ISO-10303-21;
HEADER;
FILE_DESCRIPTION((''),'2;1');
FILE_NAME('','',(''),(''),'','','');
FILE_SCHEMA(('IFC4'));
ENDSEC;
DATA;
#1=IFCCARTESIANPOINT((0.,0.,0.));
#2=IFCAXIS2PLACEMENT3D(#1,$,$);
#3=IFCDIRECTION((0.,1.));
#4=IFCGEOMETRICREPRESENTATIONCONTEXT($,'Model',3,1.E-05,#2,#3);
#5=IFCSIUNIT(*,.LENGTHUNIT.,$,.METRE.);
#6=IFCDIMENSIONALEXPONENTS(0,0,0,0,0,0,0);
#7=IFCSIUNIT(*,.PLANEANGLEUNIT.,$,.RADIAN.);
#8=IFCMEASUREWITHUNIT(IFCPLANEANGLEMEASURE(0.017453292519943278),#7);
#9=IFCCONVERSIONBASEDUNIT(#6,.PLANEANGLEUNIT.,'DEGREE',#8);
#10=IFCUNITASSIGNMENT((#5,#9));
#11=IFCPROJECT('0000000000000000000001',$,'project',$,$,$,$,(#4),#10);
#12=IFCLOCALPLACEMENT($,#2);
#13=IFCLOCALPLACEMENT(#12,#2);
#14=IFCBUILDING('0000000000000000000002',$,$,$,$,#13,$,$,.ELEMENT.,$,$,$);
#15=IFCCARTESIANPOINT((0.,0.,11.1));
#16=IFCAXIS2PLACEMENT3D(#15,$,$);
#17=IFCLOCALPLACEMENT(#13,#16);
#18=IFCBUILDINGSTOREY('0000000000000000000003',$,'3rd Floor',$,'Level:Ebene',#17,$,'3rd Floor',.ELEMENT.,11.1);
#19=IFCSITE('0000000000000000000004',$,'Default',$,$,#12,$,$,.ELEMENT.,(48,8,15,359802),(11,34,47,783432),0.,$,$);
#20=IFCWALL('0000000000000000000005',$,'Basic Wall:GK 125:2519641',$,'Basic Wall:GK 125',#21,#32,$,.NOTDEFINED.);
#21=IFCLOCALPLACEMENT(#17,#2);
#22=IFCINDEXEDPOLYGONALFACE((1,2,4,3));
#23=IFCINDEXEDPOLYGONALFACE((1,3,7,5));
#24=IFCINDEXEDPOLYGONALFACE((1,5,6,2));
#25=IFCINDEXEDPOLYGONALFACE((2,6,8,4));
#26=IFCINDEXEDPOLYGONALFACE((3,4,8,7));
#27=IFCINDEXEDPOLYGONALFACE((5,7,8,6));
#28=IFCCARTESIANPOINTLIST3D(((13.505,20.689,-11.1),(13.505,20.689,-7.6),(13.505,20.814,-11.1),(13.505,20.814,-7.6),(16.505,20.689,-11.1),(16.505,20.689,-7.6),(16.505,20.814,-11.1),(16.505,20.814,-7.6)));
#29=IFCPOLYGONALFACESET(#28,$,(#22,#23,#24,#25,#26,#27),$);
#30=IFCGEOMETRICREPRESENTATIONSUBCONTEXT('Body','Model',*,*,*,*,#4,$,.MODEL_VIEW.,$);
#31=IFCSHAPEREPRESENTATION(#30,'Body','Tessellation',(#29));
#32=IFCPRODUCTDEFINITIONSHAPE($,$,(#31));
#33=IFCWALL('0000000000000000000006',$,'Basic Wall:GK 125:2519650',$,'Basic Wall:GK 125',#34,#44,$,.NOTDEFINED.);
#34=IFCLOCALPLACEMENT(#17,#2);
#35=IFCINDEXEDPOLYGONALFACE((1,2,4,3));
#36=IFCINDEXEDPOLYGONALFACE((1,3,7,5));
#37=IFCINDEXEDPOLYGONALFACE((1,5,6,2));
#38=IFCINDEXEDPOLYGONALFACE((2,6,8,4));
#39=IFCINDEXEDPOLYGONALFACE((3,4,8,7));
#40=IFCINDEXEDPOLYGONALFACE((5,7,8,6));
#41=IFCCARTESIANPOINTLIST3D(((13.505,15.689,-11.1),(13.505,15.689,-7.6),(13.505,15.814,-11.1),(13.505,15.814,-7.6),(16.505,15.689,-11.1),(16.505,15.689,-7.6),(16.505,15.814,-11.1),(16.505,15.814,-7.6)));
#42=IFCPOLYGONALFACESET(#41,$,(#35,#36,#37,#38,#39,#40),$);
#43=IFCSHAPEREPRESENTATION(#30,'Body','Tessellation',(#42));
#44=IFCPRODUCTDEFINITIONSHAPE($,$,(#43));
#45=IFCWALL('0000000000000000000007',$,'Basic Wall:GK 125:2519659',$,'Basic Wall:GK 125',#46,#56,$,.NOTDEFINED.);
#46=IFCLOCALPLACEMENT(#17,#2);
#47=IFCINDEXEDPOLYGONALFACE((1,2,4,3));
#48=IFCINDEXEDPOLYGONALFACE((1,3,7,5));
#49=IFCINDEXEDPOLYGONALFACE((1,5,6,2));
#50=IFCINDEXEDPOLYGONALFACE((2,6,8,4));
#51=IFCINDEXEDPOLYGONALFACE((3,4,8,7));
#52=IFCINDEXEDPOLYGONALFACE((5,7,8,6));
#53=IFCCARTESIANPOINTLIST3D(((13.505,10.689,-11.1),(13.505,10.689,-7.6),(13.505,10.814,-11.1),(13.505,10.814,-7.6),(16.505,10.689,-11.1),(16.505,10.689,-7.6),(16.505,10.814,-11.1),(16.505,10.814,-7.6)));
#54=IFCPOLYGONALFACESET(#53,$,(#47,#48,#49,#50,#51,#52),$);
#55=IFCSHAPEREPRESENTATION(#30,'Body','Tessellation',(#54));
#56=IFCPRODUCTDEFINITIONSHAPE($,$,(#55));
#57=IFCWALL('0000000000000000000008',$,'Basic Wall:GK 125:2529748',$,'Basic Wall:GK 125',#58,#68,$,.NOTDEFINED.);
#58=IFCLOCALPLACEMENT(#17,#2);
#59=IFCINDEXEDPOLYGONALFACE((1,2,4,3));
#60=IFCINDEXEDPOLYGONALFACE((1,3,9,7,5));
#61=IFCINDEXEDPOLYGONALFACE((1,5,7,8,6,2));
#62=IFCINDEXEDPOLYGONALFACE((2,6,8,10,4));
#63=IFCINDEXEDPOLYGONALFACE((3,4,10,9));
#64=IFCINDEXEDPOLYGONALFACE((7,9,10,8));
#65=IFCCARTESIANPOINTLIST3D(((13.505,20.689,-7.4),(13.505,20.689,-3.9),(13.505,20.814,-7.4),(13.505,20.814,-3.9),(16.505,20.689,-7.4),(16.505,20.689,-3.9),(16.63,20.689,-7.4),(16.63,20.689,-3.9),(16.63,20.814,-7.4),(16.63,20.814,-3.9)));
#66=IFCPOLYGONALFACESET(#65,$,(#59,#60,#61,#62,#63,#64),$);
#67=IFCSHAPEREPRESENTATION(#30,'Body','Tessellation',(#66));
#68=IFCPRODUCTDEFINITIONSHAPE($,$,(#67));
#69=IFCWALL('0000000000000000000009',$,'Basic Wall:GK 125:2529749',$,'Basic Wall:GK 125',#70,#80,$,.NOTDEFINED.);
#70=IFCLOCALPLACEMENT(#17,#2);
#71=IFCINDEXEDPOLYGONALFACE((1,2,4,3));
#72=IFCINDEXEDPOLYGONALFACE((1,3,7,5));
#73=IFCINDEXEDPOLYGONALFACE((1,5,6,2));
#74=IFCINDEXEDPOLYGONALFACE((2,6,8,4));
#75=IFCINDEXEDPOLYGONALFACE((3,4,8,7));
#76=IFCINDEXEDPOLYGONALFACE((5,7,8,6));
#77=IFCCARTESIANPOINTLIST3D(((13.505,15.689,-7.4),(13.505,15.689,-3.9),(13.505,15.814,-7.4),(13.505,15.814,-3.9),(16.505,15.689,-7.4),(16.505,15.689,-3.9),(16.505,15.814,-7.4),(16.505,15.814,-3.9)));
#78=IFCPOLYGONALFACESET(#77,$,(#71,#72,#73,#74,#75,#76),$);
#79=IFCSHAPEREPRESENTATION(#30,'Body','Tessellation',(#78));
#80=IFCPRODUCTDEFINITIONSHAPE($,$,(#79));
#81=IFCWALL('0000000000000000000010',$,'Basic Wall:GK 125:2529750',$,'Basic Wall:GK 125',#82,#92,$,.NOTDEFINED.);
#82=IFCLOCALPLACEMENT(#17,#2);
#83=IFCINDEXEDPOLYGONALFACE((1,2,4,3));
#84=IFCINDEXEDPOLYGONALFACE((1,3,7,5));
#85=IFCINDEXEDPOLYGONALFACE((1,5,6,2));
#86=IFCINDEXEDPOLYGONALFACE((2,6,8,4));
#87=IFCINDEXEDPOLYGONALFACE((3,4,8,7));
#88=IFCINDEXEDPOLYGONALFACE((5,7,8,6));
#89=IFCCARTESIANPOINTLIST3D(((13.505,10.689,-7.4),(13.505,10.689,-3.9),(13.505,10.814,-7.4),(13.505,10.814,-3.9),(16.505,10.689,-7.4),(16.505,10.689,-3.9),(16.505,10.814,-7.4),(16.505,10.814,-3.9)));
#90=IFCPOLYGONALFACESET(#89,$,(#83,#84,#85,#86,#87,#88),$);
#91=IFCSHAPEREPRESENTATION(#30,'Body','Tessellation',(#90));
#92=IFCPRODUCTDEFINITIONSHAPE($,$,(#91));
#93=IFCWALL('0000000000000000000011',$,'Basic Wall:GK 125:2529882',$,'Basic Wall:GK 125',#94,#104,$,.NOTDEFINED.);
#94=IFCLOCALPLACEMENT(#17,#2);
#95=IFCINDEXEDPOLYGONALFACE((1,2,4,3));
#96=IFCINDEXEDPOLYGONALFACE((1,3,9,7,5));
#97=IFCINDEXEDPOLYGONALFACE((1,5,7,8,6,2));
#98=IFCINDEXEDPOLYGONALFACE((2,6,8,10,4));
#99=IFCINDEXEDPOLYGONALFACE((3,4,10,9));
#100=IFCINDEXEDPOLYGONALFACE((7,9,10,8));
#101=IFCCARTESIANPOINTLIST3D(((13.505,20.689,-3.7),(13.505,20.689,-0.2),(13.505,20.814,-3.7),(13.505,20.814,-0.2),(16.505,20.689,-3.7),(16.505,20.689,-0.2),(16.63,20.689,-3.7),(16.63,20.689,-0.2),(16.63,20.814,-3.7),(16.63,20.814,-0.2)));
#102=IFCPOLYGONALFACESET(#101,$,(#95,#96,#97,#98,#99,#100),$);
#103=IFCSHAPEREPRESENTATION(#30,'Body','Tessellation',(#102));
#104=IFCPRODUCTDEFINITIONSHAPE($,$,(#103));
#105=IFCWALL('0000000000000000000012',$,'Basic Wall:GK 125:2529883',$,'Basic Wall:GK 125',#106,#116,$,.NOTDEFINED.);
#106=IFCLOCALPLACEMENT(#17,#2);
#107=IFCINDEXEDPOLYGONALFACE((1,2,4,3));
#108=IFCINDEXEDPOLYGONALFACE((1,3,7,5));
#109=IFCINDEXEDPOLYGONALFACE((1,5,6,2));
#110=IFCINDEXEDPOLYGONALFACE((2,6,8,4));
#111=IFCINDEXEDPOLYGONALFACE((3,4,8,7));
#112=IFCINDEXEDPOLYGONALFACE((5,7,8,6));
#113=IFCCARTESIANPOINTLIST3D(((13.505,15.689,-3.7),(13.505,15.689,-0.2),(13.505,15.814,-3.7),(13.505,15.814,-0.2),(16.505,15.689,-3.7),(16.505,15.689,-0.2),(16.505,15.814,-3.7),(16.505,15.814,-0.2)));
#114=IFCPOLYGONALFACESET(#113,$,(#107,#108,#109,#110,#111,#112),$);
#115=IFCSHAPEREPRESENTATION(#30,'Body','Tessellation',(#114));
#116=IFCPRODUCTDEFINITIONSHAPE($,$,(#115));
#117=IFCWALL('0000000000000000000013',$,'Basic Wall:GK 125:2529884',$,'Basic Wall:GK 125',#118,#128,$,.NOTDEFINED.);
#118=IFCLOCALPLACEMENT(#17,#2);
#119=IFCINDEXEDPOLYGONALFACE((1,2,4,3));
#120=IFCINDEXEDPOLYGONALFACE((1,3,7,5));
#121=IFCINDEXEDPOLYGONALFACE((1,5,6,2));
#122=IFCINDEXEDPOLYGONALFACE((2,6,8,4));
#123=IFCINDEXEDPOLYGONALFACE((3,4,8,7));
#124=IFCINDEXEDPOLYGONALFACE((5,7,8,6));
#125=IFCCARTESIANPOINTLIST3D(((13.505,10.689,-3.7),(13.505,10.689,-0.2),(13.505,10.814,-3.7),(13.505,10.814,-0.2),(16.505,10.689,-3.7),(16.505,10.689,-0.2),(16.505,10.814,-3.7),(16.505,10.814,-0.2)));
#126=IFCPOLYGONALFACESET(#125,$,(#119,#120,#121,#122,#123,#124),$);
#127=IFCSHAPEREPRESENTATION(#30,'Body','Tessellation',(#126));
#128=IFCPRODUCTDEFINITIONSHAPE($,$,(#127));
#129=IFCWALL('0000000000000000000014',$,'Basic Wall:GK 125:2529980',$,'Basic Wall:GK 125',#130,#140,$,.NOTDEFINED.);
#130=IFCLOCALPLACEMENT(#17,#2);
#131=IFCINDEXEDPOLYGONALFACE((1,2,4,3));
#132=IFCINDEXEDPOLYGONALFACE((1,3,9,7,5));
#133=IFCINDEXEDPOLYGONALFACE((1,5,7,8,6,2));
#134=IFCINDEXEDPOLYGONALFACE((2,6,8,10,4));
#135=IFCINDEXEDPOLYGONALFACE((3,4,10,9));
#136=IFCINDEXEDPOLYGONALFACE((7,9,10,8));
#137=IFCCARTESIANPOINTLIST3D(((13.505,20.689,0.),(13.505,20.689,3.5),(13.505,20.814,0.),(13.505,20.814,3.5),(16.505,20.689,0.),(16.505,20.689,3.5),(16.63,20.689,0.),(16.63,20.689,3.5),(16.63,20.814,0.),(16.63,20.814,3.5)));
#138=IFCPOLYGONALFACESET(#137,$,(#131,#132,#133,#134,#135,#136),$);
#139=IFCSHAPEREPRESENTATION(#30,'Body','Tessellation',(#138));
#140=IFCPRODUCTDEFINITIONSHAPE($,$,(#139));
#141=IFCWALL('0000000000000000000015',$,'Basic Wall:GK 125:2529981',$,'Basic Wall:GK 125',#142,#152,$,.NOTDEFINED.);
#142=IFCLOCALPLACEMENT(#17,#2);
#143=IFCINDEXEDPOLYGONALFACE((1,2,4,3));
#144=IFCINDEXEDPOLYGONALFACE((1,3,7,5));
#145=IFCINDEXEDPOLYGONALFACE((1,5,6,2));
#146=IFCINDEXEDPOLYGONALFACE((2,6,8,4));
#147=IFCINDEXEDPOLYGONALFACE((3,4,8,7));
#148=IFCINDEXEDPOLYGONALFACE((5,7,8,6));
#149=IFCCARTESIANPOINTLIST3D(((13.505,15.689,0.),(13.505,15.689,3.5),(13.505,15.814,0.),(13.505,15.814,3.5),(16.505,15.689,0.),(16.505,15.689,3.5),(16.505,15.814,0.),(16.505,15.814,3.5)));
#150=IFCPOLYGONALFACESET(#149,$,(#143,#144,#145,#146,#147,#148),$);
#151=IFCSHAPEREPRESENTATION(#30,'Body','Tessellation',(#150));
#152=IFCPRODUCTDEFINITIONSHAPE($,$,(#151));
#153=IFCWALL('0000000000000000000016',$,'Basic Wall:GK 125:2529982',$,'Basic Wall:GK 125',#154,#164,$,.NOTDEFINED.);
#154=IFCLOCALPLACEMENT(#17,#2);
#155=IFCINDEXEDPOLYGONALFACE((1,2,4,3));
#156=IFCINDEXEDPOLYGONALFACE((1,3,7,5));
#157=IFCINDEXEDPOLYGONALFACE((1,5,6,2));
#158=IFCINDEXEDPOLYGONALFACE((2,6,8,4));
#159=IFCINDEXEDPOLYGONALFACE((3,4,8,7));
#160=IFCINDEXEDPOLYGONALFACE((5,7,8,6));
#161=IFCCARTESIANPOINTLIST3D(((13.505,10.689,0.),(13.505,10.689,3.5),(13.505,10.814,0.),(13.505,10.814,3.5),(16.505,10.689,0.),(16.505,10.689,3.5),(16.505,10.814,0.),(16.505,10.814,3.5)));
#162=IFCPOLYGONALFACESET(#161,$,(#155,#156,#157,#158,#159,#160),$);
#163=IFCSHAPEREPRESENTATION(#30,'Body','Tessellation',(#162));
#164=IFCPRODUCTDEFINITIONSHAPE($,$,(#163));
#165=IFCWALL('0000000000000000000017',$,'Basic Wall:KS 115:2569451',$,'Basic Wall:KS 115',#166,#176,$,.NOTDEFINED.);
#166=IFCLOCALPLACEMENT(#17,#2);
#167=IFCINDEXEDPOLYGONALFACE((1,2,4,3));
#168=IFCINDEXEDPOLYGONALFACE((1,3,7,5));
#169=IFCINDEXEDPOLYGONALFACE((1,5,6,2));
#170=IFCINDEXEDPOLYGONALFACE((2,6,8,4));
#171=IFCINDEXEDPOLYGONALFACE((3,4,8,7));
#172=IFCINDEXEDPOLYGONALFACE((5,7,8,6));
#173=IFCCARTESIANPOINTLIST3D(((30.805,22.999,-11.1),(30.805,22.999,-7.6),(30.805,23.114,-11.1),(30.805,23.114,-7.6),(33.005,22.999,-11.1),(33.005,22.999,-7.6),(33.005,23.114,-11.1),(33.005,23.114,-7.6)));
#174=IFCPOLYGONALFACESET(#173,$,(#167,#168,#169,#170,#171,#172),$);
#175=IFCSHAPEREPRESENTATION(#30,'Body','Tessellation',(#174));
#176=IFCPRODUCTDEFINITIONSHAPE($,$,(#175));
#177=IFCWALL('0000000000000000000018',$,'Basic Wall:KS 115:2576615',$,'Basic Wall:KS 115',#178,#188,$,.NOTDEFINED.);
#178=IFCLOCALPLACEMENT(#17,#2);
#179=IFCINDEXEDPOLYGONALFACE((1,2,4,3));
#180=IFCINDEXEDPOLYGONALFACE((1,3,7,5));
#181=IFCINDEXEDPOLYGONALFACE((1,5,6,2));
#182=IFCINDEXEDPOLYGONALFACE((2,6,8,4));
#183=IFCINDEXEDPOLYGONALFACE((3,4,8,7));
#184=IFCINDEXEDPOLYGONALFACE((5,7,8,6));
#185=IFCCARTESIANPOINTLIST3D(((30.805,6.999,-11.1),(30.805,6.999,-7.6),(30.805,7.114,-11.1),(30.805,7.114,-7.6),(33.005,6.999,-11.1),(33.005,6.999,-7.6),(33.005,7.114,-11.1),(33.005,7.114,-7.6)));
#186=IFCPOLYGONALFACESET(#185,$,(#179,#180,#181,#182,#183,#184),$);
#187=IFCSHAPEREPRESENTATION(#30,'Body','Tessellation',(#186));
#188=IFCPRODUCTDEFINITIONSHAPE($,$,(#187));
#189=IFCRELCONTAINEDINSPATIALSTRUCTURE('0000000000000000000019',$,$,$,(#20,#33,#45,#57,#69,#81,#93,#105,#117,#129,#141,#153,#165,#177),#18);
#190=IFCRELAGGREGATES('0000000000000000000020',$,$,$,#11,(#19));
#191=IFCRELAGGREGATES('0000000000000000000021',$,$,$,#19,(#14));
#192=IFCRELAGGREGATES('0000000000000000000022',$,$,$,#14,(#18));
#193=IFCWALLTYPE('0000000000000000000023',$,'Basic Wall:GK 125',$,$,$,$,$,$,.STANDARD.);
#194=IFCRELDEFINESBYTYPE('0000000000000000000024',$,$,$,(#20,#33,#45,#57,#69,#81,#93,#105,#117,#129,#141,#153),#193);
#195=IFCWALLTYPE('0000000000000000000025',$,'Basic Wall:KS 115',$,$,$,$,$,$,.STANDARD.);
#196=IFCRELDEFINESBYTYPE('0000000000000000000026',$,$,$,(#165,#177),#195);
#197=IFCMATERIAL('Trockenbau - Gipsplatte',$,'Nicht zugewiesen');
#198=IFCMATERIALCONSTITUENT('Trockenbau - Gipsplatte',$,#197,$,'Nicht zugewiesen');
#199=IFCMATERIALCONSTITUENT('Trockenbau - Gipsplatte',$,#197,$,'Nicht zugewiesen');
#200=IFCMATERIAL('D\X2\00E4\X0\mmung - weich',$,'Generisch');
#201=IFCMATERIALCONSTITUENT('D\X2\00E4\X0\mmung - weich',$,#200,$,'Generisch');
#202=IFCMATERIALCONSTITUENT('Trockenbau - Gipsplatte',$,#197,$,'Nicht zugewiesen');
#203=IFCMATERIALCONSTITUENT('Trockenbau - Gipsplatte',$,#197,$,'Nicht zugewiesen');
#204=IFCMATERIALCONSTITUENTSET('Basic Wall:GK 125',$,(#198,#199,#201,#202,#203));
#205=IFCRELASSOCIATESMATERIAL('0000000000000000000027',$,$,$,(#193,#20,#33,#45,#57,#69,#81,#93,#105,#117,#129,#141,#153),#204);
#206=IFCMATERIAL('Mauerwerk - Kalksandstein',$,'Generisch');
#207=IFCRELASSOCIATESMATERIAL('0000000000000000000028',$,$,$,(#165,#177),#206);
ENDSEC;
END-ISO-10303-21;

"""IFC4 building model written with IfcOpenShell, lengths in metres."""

from ifc_helpers import new_model, entity, si_unit, converted_unit, direction, frame, origin, place, context, subcontext, project, spatial, indexed_curve, outline, extrude, material, constituent, constituent_set, type_object, element, save


model = new_model("IFC4")

# Units and contexts
model_context = context("Model", 3, precision=1e-05, world=origin(), true_north=direction((0.0, 1.0)))
body_context = subcontext(model_context, "Body", "Model", "MODEL_VIEW")
ifc_project = project(units=[si_unit("LENGTHUNIT", "METRE"), converted_unit("PLANEANGLEUNIT", "DEGREE", entity("IfcPlaneAngleMeasure", 0.017453292519943278), si_unit("PLANEANGLEUNIT", "RADIAN"), dimensions=[0, 0, 0, 0, 0, 0, 0])], contexts=[model_context])

# Site, building, storey
site_placement = place(None, origin())
site = spatial("IfcSite", under=ifc_project, at=site_placement, Name="Default", CompositionType="ELEMENT", RefLatitude=(48, 8, 15, 359802), RefLongitude=(11, 34, 47, 783432), RefElevation=0.0)
building_placement = place(site_placement, origin())
building = spatial("IfcBuilding", under=site, at=building_placement, CompositionType="ELEMENT")
storey_placement = place(building_placement, frame((0.0, 0.0, 11.1)))
storey = spatial("IfcBuildingStorey", under=building, at=storey_placement, Name="3rd Floor", ObjectType="Level:Ebene", LongName="3rd Floor", CompositionType="ELEMENT", Elevation=11.1)

# Walls
ifc_material_1 = material(Name="Trockenbau - Gipsplatte", Category="Nicht zugewiesen")
ifc_constituent_1 = constituent(ifc_material_1, Name="Trockenbau - Gipsplatte", Category="Nicht zugewiesen")
ifc_constituent_2 = constituent(ifc_material_1, Name="Trockenbau - Gipsplatte", Category="Nicht zugewiesen")
ifc_material_2 = material(Name="Dämmung - weich", Category="Generisch")
ifc_constituent_3 = constituent(ifc_material_2, Name="Dämmung - weich", Category="Generisch")
ifc_constituent_4 = constituent(ifc_material_1, Name="Trockenbau - Gipsplatte", Category="Nicht zugewiesen")
ifc_constituent_5 = constituent(ifc_material_1, Name="Trockenbau - Gipsplatte", Category="Nicht zugewiesen")
ifc_constituent_set = constituent_set(constituents=[ifc_constituent_1, ifc_constituent_2, ifc_constituent_3, ifc_constituent_4, ifc_constituent_5], Name="Basic Wall:GK 125")
wall_type_1 = type_object("IfcWallType", Name="Basic Wall:GK 125", PredefinedType="STANDARD", material=ifc_constituent_set)
wall_1_placement = place(storey_placement, frame((13.505, 20.7515, -11.1)))
element("IfcWall", 1, at=wall_1_placement, inside=storey, type_object=wall_type_1, material=ifc_constituent_set, Name="Basic Wall:GK 125:2519641", ObjectType="Basic Wall:GK 125", PredefinedType="NOTDEFINED", context=body_context, shape_type="SweptSolid", body=[
    extrude(outline(indexed_curve([(3.0, -0.0625), (3.0, 0.0625), (0.0, 0.0625), (0.0, -0.0625), (3.0, -0.0625)], self_intersect=False)), origin(), (0.0, 0.0, 1.0), 3.5),
])
for number, where, name in (
    (2, (13.505, 15.7515, -11.1), "Basic Wall:GK 125:2519650"),
    (3, (13.505, 10.7515, -11.1), "Basic Wall:GK 125:2519659"),
):
    element("IfcWall", number, at=place(storey_placement, frame(where)), inside=storey, type_object=wall_type_1, material=ifc_constituent_set, Name=name, ObjectType="Basic Wall:GK 125", PredefinedType="NOTDEFINED", context=body_context, shape_type="SweptSolid", body=[
        extrude(outline(indexed_curve([(3.0, -0.0625), (3.0, 0.0625), (0.0, 0.0625), (0.0, -0.0625), (3.0, -0.0625)], self_intersect=False)), origin(), (0.0, 0.0, 1.0), 3.5),
    ])
wall_2_placement = place(storey_placement, frame((13.505, 20.7515, -7.4)))
element("IfcWall", 4, at=wall_2_placement, inside=storey, type_object=wall_type_1, material=ifc_constituent_set, Name="Basic Wall:GK 125:2529748", ObjectType="Basic Wall:GK 125", PredefinedType="NOTDEFINED", context=body_context, shape_type="SweptSolid", body=[
    extrude(outline(indexed_curve([(3.125, -0.0625), (3.125, 0.0625), (0.0, 0.0625), (0.0, -0.0625), (3.0, -0.0625), (3.125, -0.0625)], self_intersect=False)), origin(), (0.0, 0.0, 1.0), 3.5),
])
for number, where, name in (
    (5, (13.505, 15.7515, -7.4), "Basic Wall:GK 125:2529749"),
    (6, (13.505, 10.7515, -7.4), "Basic Wall:GK 125:2529750"),
):
    element("IfcWall", number, at=place(storey_placement, frame(where)), inside=storey, type_object=wall_type_1, material=ifc_constituent_set, Name=name, ObjectType="Basic Wall:GK 125", PredefinedType="NOTDEFINED", context=body_context, shape_type="SweptSolid", body=[
        extrude(outline(indexed_curve([(3.0, -0.0625), (3.0, 0.0625), (0.0, 0.0625), (0.0, -0.0625), (3.0, -0.0625)], self_intersect=False)), origin(), (0.0, 0.0, 1.0), 3.5),
    ])
wall_3_placement = place(storey_placement, frame((13.505, 20.7515, -3.7)))
element("IfcWall", 7, at=wall_3_placement, inside=storey, type_object=wall_type_1, material=ifc_constituent_set, Name="Basic Wall:GK 125:2529882", ObjectType="Basic Wall:GK 125", PredefinedType="NOTDEFINED", context=body_context, shape_type="SweptSolid", body=[
    extrude(outline(indexed_curve([(3.125, -0.0625), (3.125, 0.0625), (0.0, 0.0625), (0.0, -0.0625), (3.0, -0.0625), (3.125, -0.0625)], self_intersect=False)), origin(), (0.0, 0.0, 1.0), 3.5),
])
for number, where, name in (
    (8, (13.505, 15.7515, -3.7), "Basic Wall:GK 125:2529883"),
    (9, (13.505, 10.7515, -3.7), "Basic Wall:GK 125:2529884"),
):
    element("IfcWall", number, at=place(storey_placement, frame(where)), inside=storey, type_object=wall_type_1, material=ifc_constituent_set, Name=name, ObjectType="Basic Wall:GK 125", PredefinedType="NOTDEFINED", context=body_context, shape_type="SweptSolid", body=[
        extrude(outline(indexed_curve([(3.0, -0.0625), (3.0, 0.0625), (0.0, 0.0625), (0.0, -0.0625), (3.0, -0.0625)], self_intersect=False)), origin(), (0.0, 0.0, 1.0), 3.5),
    ])
wall_4_placement = place(storey_placement, frame((13.505, 20.7515, 0.0)))
element("IfcWall", 10, at=wall_4_placement, inside=storey, type_object=wall_type_1, material=ifc_constituent_set, Name="Basic Wall:GK 125:2529980", ObjectType="Basic Wall:GK 125", PredefinedType="NOTDEFINED", context=body_context, shape_type="SweptSolid", body=[
    extrude(outline(indexed_curve([(3.125, -0.0625), (3.125, 0.0625), (0.0, 0.0625), (0.0, -0.0625), (3.0, -0.0625), (3.125, -0.0625)], self_intersect=False)), origin(), (0.0, 0.0, 1.0), 3.5),
])
for number, where, name in (
    (11, (13.505, 15.7515, 0.0), "Basic Wall:GK 125:2529981"),
    (12, (13.505, 10.7515, 0.0), "Basic Wall:GK 125:2529982"),
):
    element("IfcWall", number, at=place(storey_placement, frame(where)), inside=storey, type_object=wall_type_1, material=ifc_constituent_set, Name=name, ObjectType="Basic Wall:GK 125", PredefinedType="NOTDEFINED", context=body_context, shape_type="SweptSolid", body=[
        extrude(outline(indexed_curve([(3.0, -0.0625), (3.0, 0.0625), (0.0, 0.0625), (0.0, -0.0625), (3.0, -0.0625)], self_intersect=False)), origin(), (0.0, 0.0, 1.0), 3.5),
    ])
ifc_material_3 = material(Name="Mauerwerk - Kalksandstein", Category="Generisch")
wall_type_2 = type_object("IfcWallType", Name="Basic Wall:KS 115", PredefinedType="STANDARD")
wall_5_placement = place(storey_placement, frame((30.805, 23.0565, -11.1)))
element("IfcWall", 13, at=wall_5_placement, inside=storey, type_object=wall_type_2, material=ifc_material_3, Name="Basic Wall:KS 115:2569451", ObjectType="Basic Wall:KS 115", PredefinedType="NOTDEFINED", context=body_context, shape_type="SweptSolid", body=[
    extrude(outline(indexed_curve([(2.2, -0.0575), (2.2, 0.0575), (0.0, 0.0575), (0.0, -0.0575), (2.2, -0.0575)], self_intersect=False)), origin(), (0.0, 0.0, 1.0), 3.5),
])
wall_6_placement = place(storey_placement, frame((30.805, 7.0565, -11.1)))
element("IfcWall", 14, at=wall_6_placement, inside=storey, type_object=wall_type_2, material=ifc_material_3, Name="Basic Wall:KS 115:2576615", ObjectType="Basic Wall:KS 115", PredefinedType="NOTDEFINED", context=body_context, shape_type="SweptSolid", body=[
    extrude(outline(indexed_curve([(2.2, -0.0575), (2.2, 0.0575), (0.0, 0.0575), (0.0, -0.0575), (2.2, -0.0575)], self_intersect=False)), origin(), (0.0, 0.0, 1.0), 3.5),
])

save(model, "model.ifc")
